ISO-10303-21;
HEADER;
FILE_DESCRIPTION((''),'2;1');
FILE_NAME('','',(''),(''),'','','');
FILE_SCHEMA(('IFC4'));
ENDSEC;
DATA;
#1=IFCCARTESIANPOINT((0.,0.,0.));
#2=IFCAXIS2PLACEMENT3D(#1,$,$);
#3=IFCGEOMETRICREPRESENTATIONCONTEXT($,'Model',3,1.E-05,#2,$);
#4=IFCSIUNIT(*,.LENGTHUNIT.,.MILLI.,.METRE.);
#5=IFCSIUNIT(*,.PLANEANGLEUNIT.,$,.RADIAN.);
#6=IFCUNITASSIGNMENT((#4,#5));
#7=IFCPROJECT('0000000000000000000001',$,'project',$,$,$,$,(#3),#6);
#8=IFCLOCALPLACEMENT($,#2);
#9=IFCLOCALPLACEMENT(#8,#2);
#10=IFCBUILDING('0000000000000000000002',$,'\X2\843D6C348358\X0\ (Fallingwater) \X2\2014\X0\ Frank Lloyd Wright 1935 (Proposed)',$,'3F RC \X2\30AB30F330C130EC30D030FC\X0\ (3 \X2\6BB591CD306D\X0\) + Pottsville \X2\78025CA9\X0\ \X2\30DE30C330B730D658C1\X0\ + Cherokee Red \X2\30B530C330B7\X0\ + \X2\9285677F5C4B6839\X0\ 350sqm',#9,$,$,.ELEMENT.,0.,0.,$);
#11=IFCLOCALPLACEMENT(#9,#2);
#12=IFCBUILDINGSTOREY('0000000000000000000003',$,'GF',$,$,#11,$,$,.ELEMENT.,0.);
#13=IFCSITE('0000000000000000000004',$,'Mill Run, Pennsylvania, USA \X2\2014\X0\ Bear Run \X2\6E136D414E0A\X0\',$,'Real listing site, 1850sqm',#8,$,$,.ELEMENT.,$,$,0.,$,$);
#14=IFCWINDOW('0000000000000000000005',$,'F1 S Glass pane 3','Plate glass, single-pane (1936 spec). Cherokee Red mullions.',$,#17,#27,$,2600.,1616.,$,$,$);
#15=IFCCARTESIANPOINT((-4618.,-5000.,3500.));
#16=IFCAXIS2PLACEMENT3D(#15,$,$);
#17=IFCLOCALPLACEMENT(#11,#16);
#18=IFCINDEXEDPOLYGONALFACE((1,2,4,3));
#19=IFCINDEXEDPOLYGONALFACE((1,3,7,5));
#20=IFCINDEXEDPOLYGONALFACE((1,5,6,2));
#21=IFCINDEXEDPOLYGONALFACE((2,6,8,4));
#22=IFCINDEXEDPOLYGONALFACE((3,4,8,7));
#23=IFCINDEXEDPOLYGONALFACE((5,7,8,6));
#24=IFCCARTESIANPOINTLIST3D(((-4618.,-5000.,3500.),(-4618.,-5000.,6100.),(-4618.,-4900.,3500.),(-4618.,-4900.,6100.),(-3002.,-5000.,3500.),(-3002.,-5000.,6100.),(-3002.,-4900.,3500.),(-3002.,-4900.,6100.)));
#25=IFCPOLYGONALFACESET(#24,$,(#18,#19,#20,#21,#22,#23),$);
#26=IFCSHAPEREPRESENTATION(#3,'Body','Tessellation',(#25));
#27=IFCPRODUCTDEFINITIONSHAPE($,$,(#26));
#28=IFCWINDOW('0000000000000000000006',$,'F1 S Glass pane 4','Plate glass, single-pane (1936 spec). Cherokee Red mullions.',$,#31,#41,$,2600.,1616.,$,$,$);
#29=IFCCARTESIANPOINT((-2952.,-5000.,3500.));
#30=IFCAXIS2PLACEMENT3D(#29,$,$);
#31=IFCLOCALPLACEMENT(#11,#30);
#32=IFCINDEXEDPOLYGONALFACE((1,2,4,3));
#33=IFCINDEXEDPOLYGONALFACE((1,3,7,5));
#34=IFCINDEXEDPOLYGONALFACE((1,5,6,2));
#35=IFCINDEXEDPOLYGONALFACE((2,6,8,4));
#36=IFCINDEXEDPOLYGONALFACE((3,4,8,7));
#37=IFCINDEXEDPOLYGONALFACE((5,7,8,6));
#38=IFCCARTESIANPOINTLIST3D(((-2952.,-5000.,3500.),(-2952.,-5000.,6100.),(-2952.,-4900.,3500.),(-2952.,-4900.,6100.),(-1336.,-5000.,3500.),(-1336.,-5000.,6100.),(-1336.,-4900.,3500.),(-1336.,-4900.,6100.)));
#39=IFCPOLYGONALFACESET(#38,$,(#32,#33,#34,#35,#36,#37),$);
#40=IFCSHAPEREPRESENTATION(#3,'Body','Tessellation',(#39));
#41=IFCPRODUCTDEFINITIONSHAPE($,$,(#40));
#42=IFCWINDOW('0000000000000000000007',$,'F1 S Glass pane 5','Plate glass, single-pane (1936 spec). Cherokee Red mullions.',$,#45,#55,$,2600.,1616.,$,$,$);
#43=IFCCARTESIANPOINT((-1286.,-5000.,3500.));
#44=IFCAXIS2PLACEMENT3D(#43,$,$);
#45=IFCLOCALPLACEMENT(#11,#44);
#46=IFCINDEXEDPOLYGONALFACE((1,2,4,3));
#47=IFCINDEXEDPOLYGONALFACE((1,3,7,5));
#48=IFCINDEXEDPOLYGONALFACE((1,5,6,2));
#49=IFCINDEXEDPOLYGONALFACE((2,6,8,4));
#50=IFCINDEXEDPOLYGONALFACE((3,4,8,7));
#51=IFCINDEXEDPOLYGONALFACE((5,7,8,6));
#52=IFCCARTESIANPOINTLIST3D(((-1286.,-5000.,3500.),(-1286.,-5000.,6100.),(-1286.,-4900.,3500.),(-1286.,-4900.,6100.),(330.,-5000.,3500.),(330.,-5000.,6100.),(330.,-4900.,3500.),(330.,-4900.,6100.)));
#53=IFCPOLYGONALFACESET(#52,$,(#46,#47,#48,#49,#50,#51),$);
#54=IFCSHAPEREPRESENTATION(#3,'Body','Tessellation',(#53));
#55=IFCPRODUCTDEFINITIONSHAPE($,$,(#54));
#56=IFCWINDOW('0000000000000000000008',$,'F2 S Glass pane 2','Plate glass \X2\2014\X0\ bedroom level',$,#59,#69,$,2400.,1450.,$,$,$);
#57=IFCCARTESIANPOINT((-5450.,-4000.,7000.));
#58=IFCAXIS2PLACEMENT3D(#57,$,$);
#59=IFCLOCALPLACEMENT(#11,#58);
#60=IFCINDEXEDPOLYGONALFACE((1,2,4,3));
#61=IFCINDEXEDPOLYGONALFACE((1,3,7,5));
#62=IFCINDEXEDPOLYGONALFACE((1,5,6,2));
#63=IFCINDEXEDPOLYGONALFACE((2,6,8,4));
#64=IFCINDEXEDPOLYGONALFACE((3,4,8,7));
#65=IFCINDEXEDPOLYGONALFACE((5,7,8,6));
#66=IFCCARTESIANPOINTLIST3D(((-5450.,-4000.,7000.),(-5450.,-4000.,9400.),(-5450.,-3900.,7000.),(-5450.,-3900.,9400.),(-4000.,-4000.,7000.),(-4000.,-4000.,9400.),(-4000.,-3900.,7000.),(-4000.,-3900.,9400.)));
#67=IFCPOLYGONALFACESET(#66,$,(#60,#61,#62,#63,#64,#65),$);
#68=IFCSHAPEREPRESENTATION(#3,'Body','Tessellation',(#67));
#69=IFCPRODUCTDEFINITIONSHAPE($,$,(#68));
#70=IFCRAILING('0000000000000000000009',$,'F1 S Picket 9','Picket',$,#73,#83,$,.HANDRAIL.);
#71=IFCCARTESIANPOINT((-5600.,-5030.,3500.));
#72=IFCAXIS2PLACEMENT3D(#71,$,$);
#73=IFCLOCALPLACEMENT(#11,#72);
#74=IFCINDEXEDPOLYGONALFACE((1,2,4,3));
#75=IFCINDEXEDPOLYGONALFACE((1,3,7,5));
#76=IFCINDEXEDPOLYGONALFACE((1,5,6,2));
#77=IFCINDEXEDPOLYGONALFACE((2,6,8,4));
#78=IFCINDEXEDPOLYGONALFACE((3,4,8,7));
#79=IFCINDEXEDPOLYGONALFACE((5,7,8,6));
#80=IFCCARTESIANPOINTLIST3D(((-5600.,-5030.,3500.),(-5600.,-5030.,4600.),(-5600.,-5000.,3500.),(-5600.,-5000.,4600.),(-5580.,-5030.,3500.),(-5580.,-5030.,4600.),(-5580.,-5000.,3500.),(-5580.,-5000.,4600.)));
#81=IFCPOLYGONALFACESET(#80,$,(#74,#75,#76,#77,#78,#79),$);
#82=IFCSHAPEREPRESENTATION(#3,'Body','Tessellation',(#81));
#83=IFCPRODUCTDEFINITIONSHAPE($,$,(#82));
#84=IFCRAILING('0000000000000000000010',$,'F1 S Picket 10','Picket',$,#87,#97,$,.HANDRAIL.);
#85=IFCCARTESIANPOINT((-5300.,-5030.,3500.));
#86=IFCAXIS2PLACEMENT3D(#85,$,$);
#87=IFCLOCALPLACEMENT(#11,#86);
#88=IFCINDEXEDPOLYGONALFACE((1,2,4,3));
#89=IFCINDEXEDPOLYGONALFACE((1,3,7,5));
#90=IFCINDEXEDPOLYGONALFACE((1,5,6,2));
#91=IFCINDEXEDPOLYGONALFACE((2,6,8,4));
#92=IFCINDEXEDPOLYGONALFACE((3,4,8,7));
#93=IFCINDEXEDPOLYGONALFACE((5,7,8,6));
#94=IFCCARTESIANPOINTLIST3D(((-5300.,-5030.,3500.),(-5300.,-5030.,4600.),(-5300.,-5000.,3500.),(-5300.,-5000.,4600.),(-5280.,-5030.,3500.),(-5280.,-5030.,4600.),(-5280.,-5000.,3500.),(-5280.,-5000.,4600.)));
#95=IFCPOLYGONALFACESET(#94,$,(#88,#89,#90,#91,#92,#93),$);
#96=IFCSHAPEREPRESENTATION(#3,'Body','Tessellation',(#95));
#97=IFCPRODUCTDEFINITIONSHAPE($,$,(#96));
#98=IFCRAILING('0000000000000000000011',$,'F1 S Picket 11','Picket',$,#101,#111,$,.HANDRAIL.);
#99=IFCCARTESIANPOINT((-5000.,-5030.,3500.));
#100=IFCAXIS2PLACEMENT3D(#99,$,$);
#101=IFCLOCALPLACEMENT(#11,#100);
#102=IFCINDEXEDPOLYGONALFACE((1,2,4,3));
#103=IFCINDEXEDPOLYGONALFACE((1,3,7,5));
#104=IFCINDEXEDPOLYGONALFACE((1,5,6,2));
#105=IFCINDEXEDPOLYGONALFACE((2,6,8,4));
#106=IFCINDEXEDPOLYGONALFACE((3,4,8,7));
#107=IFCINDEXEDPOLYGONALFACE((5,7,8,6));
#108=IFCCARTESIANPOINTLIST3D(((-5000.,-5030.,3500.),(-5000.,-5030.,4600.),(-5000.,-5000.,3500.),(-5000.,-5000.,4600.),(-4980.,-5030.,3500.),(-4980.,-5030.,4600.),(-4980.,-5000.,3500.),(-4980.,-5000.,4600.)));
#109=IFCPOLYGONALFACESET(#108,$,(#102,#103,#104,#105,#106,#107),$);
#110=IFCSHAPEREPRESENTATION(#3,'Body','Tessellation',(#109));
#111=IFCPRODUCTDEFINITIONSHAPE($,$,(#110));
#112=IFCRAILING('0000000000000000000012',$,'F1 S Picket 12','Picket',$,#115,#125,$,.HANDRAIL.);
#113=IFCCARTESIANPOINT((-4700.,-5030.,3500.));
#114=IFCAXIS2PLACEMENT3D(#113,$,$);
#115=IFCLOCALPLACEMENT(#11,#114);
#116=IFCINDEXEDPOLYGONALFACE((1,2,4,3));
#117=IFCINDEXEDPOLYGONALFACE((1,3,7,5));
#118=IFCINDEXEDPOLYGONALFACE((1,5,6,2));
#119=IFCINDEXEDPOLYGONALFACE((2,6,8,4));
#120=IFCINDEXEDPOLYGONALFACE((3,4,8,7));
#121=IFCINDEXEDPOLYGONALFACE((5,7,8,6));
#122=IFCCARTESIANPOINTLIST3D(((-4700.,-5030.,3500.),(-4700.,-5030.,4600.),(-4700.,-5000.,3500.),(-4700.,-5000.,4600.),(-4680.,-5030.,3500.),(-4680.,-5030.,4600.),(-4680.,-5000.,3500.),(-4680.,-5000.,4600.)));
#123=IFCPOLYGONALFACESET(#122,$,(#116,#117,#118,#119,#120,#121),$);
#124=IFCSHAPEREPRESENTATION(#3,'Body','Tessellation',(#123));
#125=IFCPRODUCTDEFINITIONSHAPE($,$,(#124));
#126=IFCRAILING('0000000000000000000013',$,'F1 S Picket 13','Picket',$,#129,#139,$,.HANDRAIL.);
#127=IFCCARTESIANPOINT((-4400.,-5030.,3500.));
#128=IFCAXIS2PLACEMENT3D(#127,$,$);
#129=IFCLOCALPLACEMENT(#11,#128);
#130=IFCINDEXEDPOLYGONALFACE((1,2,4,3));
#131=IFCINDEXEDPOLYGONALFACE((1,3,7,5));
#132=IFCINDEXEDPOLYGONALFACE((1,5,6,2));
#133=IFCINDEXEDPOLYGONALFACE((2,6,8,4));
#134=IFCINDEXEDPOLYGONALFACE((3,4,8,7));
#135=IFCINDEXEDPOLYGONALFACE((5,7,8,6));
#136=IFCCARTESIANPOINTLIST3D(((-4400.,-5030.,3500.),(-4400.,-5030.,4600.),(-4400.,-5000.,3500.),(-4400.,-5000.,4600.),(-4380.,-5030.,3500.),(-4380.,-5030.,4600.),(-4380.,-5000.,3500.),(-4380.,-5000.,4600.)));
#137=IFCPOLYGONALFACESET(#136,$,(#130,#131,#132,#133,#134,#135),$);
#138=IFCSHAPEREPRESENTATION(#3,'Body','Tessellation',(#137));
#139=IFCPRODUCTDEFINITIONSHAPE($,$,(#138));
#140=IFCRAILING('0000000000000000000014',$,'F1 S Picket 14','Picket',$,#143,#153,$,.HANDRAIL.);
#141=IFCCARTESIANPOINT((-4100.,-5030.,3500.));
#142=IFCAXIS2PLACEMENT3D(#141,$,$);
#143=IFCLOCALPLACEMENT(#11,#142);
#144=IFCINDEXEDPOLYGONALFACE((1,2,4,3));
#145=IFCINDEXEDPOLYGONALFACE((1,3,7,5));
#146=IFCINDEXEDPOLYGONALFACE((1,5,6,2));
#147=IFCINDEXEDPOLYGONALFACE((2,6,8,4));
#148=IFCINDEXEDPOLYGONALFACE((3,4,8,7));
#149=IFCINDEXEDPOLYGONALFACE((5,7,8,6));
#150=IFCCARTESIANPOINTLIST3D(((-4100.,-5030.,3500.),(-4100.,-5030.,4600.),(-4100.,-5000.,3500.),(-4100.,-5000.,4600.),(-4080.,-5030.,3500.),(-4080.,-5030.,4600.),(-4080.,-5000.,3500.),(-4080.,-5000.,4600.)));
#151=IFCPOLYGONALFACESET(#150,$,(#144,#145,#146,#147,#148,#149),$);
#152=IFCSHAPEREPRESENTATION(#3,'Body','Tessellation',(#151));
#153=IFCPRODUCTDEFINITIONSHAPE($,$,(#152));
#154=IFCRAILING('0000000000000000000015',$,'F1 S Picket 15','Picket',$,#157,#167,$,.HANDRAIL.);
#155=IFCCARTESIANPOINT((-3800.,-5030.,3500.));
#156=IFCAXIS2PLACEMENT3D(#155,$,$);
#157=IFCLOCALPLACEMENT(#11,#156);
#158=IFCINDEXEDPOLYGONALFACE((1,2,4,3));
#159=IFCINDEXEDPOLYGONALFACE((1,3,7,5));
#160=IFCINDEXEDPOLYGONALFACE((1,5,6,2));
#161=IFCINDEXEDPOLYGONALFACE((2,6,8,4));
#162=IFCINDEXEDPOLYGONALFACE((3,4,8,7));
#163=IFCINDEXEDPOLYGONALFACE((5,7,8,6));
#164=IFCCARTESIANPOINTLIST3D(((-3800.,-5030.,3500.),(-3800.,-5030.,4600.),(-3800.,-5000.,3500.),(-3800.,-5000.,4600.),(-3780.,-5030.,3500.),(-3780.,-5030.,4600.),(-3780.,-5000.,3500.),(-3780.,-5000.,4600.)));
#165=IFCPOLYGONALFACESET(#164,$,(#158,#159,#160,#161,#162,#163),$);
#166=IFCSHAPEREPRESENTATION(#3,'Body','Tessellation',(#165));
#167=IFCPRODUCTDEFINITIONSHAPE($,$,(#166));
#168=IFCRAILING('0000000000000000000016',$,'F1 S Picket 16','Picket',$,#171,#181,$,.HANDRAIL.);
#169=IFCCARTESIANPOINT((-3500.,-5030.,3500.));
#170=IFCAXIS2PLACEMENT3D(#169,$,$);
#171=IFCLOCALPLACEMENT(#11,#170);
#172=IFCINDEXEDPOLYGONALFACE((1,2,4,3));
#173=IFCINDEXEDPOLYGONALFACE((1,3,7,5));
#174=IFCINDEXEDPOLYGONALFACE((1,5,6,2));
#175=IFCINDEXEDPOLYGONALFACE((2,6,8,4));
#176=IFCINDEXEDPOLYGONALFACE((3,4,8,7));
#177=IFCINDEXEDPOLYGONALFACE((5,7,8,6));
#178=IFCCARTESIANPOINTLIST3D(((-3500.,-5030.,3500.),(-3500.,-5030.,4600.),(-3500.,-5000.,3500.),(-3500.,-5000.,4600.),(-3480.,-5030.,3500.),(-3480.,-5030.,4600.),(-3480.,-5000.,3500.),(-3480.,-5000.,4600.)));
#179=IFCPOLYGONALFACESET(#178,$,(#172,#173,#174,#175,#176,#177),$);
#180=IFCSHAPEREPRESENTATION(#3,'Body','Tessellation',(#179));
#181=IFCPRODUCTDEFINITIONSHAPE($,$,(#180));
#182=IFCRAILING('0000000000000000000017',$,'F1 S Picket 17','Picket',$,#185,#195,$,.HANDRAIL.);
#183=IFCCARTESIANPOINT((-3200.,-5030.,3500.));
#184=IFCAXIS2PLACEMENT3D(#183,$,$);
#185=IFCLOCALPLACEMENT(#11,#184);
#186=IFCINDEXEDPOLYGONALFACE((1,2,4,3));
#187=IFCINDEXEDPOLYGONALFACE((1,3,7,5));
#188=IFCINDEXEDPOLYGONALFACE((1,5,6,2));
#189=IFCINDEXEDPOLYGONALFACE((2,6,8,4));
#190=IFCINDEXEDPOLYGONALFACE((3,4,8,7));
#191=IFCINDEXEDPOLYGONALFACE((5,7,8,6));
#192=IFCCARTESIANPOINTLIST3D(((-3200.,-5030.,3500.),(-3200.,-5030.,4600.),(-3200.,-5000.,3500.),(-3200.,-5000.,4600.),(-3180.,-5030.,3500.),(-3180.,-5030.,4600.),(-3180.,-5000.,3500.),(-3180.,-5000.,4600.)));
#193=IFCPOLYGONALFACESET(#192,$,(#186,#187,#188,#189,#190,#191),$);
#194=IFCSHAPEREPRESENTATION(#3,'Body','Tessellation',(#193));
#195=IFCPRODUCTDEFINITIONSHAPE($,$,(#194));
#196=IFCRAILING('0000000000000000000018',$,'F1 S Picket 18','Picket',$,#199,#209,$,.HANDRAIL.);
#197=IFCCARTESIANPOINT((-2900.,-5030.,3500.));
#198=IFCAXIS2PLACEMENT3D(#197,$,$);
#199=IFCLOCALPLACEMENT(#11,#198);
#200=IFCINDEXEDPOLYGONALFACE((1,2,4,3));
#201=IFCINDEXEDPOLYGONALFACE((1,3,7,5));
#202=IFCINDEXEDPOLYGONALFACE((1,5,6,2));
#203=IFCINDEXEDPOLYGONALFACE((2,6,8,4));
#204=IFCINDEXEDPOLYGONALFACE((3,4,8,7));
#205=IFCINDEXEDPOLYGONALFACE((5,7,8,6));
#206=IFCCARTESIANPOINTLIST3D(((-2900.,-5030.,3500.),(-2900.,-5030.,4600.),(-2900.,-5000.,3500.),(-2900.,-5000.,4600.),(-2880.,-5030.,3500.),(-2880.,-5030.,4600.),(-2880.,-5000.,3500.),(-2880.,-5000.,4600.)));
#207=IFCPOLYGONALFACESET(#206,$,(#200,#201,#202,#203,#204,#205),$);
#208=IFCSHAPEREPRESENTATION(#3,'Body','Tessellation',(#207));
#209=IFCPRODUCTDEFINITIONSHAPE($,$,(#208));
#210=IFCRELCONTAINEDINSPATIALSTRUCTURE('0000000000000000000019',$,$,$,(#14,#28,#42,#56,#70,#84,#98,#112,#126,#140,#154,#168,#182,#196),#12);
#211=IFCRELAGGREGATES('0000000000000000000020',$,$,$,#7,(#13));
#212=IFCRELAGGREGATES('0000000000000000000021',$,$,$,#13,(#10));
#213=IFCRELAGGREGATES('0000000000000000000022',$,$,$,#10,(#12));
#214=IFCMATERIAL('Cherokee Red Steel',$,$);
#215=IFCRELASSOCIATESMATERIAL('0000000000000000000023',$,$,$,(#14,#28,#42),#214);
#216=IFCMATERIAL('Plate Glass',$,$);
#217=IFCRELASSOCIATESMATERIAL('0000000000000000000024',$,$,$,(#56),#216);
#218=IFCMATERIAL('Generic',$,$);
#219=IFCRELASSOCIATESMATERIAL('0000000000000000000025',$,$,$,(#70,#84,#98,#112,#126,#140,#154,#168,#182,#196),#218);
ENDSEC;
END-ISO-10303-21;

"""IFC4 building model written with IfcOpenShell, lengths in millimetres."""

from ifc_helpers import new_model, si_unit, frame, frame_2d, origin, place, context, project, spatial, rectangle, extrude, material, element, save


model = new_model("IFC4")

# Units and contexts
model_context = context("Model", 3, precision=1e-05, world=origin())
ifc_project = project(units=[si_unit("LENGTHUNIT", "METRE", prefix="MILLI"), si_unit("PLANEANGLEUNIT", "RADIAN")], contexts=[model_context])

# Site, building, storey
site_placement = place(None, origin())
site = spatial("IfcSite", under=ifc_project, at=site_placement, Name="Mill Run, Pennsylvania, USA — Bear Run 渓流上", ObjectType="Real listing site, 1850sqm", CompositionType="ELEMENT", RefElevation=0.0)
building_placement = place(site_placement, origin())
building = spatial("IfcBuilding", under=site, at=building_placement, Name="落水荘 (Fallingwater) — Frank Lloyd Wright 1935 (Proposed)", ObjectType="3F RC カンチレバー (3 段重ね) + Pottsville 砂岩 マッシブ壁 + Cherokee Red サッシ + 銅板屋根 350sqm", CompositionType="ELEMENT", ElevationOfRefHeight=0.0, ElevationOfTerrain=0.0)
storey_placement = place(building_placement, origin())
storey = spatial("IfcBuildingStorey", under=building, at=storey_placement, Name="GF", CompositionType="ELEMENT", Elevation=0.0)

# Windows
ifc_material_1 = material(Name="Cherokee Red Steel")
window_1_placement = place(storey_placement, frame((-4618.0, -5000.0, 3500.0)))
element("IfcWindow", 1, at=window_1_placement, inside=storey, material=ifc_material_1, Name="F1 S Glass pane 3", Description="Plate glass, single-pane (1936 spec). Cherokee Red mullions.", OverallHeight=2600.0, OverallWidth=1616.0, context=model_context, shape_type="SweptSolid", body=[
    extrude(rectangle(XDim=1616.0, YDim=100.0, at=frame_2d((808.0, 50.0))), frame((-4618.0, -5000.0, 3500.0)), (0.0, 0.0, 1.0), 2600.0),
])
window_2_placement = place(storey_placement, frame((-2952.0, -5000.0, 3500.0)))
element("IfcWindow", 2, at=window_2_placement, inside=storey, material=ifc_material_1, Name="F1 S Glass pane 4", Description="Plate glass, single-pane (1936 spec). Cherokee Red mullions.", OverallHeight=2600.0, OverallWidth=1616.0, context=model_context, shape_type="SweptSolid", body=[
    extrude(rectangle(XDim=1616.0, YDim=100.0, at=frame_2d((808.0, 50.0))), frame((-2952.0, -5000.0, 3500.0)), (0.0, 0.0, 1.0), 2600.0),
])
window_3_placement = place(storey_placement, frame((-1286.0, -5000.0, 3500.0)))
element("IfcWindow", 3, at=window_3_placement, inside=storey, material=ifc_material_1, Name="F1 S Glass pane 5", Description="Plate glass, single-pane (1936 spec). Cherokee Red mullions.", OverallHeight=2600.0, OverallWidth=1616.0, context=model_context, shape_type="SweptSolid", body=[
    extrude(rectangle(XDim=1616.0, YDim=100.0, at=frame_2d((808.0, 50.0))), frame((-1286.0, -5000.0, 3500.0)), (0.0, 0.0, 1.0), 2600.0),
])
ifc_material_2 = material(Name="Plate Glass")
window_4_placement = place(storey_placement, frame((-5450.0, -4000.0, 7000.0)))
element("IfcWindow", 4, at=window_4_placement, inside=storey, material=ifc_material_2, Name="F2 S Glass pane 2", Description="Plate glass — bedroom level", OverallHeight=2400.0, OverallWidth=1450.0, context=model_context, shape_type="SweptSolid", body=[
    extrude(rectangle(XDim=1450.0, YDim=100.0, at=frame_2d((725.0, 50.0))), frame((-5450.0, -4000.0, 7000.0)), (0.0, 0.0, 1.0), 2400.0),
])

# Railings
ifc_material_3 = material(Name="Generic")
railing_1_placement = place(storey_placement, frame((-5600.0, -5030.0, 3500.0)))
element("IfcRailing", 5, at=railing_1_placement, inside=storey, material=ifc_material_3, Name="F1 S Picket 9", Description="Picket", PredefinedType="HANDRAIL", context=model_context, shape_type="SweptSolid", body=[
    extrude(rectangle(XDim=20.0, YDim=30.0, at=frame_2d((10.0, 15.0))), frame((-5600.0, -5030.0, 3500.0)), (0.0, 0.0, 1.0), 1100.0),
])
railing_2_placement = place(storey_placement, frame((-5300.0, -5030.0, 3500.0)))
element("IfcRailing", 6, at=railing_2_placement, inside=storey, material=ifc_material_3, Name="F1 S Picket 10", Description="Picket", PredefinedType="HANDRAIL", context=model_context, shape_type="SweptSolid", body=[
    extrude(rectangle(XDim=20.0, YDim=30.0, at=frame_2d((10.0, 15.0))), frame((-5300.0, -5030.0, 3500.0)), (0.0, 0.0, 1.0), 1100.0),
])
railing_3_placement = place(storey_placement, frame((-5000.0, -5030.0, 3500.0)))
element("IfcRailing", 7, at=railing_3_placement, inside=storey, material=ifc_material_3, Name="F1 S Picket 11", Description="Picket", PredefinedType="HANDRAIL", context=model_context, shape_type="SweptSolid", body=[
    extrude(rectangle(XDim=20.0, YDim=30.0, at=frame_2d((10.0, 15.0))), frame((-5000.0, -5030.0, 3500.0)), (0.0, 0.0, 1.0), 1100.0),
])
railing_4_placement = place(storey_placement, frame((-4700.0, -5030.0, 3500.0)))
element("IfcRailing", 8, at=railing_4_placement, inside=storey, material=ifc_material_3, Name="F1 S Picket 12", Description="Picket", PredefinedType="HANDRAIL", context=model_context, shape_type="SweptSolid", body=[
    extrude(rectangle(XDim=20.0, YDim=30.0, at=frame_2d((10.0, 15.0))), frame((-4700.0, -5030.0, 3500.0)), (0.0, 0.0, 1.0), 1100.0),
])
railing_5_placement = place(storey_placement, frame((-4400.0, -5030.0, 3500.0)))
element("IfcRailing", 9, at=railing_5_placement, inside=storey, material=ifc_material_3, Name="F1 S Picket 13", Description="Picket", PredefinedType="HANDRAIL", context=model_context, shape_type="SweptSolid", body=[
    extrude(rectangle(XDim=20.0, YDim=30.0, at=frame_2d((10.0, 15.0))), frame((-4400.0, -5030.0, 3500.0)), (0.0, 0.0, 1.0), 1100.0),
])
railing_6_placement = place(storey_placement, frame((-4100.0, -5030.0, 3500.0)))
element("IfcRailing", 10, at=railing_6_placement, inside=storey, material=ifc_material_3, Name="F1 S Picket 14", Description="Picket", PredefinedType="HANDRAIL", context=model_context, shape_type="SweptSolid", body=[
    extrude(rectangle(XDim=20.0, YDim=30.0, at=frame_2d((10.0, 15.0))), frame((-4100.0, -5030.0, 3500.0)), (0.0, 0.0, 1.0), 1100.0),
])
railing_7_placement = place(storey_placement, frame((-3800.0, -5030.0, 3500.0)))
element("IfcRailing", 11, at=railing_7_placement, inside=storey, material=ifc_material_3, Name="F1 S Picket 15", Description="Picket", PredefinedType="HANDRAIL", context=model_context, shape_type="SweptSolid", body=[
    extrude(rectangle(XDim=20.0, YDim=30.0, at=frame_2d((10.0, 15.0))), frame((-3800.0, -5030.0, 3500.0)), (0.0, 0.0, 1.0), 1100.0),
])
railing_8_placement = place(storey_placement, frame((-3500.0, -5030.0, 3500.0)))
element("IfcRailing", 12, at=railing_8_placement, inside=storey, material=ifc_material_3, Name="F1 S Picket 16", Description="Picket", PredefinedType="HANDRAIL", context=model_context, shape_type="SweptSolid", body=[
    extrude(rectangle(XDim=20.0, YDim=30.0, at=frame_2d((10.0, 15.0))), frame((-3500.0, -5030.0, 3500.0)), (0.0, 0.0, 1.0), 1100.0),
])
railing_9_placement = place(storey_placement, frame((-3200.0, -5030.0, 3500.0)))
element("IfcRailing", 13, at=railing_9_placement, inside=storey, material=ifc_material_3, Name="F1 S Picket 17", Description="Picket", PredefinedType="HANDRAIL", context=model_context, shape_type="SweptSolid", body=[
    extrude(rectangle(XDim=20.0, YDim=30.0, at=frame_2d((10.0, 15.0))), frame((-3200.0, -5030.0, 3500.0)), (0.0, 0.0, 1.0), 1100.0),
])
railing_10_placement = place(storey_placement, frame((-2900.0, -5030.0, 3500.0)))
element("IfcRailing", 14, at=railing_10_placement, inside=storey, material=ifc_material_3, Name="F1 S Picket 18", Description="Picket", PredefinedType="HANDRAIL", context=model_context, shape_type="SweptSolid", body=[
    extrude(rectangle(XDim=20.0, YDim=30.0, at=frame_2d((10.0, 15.0))), frame((-2900.0, -5030.0, 3500.0)), (0.0, 0.0, 1.0), 1100.0),
])

save(model, "model.ifc")
